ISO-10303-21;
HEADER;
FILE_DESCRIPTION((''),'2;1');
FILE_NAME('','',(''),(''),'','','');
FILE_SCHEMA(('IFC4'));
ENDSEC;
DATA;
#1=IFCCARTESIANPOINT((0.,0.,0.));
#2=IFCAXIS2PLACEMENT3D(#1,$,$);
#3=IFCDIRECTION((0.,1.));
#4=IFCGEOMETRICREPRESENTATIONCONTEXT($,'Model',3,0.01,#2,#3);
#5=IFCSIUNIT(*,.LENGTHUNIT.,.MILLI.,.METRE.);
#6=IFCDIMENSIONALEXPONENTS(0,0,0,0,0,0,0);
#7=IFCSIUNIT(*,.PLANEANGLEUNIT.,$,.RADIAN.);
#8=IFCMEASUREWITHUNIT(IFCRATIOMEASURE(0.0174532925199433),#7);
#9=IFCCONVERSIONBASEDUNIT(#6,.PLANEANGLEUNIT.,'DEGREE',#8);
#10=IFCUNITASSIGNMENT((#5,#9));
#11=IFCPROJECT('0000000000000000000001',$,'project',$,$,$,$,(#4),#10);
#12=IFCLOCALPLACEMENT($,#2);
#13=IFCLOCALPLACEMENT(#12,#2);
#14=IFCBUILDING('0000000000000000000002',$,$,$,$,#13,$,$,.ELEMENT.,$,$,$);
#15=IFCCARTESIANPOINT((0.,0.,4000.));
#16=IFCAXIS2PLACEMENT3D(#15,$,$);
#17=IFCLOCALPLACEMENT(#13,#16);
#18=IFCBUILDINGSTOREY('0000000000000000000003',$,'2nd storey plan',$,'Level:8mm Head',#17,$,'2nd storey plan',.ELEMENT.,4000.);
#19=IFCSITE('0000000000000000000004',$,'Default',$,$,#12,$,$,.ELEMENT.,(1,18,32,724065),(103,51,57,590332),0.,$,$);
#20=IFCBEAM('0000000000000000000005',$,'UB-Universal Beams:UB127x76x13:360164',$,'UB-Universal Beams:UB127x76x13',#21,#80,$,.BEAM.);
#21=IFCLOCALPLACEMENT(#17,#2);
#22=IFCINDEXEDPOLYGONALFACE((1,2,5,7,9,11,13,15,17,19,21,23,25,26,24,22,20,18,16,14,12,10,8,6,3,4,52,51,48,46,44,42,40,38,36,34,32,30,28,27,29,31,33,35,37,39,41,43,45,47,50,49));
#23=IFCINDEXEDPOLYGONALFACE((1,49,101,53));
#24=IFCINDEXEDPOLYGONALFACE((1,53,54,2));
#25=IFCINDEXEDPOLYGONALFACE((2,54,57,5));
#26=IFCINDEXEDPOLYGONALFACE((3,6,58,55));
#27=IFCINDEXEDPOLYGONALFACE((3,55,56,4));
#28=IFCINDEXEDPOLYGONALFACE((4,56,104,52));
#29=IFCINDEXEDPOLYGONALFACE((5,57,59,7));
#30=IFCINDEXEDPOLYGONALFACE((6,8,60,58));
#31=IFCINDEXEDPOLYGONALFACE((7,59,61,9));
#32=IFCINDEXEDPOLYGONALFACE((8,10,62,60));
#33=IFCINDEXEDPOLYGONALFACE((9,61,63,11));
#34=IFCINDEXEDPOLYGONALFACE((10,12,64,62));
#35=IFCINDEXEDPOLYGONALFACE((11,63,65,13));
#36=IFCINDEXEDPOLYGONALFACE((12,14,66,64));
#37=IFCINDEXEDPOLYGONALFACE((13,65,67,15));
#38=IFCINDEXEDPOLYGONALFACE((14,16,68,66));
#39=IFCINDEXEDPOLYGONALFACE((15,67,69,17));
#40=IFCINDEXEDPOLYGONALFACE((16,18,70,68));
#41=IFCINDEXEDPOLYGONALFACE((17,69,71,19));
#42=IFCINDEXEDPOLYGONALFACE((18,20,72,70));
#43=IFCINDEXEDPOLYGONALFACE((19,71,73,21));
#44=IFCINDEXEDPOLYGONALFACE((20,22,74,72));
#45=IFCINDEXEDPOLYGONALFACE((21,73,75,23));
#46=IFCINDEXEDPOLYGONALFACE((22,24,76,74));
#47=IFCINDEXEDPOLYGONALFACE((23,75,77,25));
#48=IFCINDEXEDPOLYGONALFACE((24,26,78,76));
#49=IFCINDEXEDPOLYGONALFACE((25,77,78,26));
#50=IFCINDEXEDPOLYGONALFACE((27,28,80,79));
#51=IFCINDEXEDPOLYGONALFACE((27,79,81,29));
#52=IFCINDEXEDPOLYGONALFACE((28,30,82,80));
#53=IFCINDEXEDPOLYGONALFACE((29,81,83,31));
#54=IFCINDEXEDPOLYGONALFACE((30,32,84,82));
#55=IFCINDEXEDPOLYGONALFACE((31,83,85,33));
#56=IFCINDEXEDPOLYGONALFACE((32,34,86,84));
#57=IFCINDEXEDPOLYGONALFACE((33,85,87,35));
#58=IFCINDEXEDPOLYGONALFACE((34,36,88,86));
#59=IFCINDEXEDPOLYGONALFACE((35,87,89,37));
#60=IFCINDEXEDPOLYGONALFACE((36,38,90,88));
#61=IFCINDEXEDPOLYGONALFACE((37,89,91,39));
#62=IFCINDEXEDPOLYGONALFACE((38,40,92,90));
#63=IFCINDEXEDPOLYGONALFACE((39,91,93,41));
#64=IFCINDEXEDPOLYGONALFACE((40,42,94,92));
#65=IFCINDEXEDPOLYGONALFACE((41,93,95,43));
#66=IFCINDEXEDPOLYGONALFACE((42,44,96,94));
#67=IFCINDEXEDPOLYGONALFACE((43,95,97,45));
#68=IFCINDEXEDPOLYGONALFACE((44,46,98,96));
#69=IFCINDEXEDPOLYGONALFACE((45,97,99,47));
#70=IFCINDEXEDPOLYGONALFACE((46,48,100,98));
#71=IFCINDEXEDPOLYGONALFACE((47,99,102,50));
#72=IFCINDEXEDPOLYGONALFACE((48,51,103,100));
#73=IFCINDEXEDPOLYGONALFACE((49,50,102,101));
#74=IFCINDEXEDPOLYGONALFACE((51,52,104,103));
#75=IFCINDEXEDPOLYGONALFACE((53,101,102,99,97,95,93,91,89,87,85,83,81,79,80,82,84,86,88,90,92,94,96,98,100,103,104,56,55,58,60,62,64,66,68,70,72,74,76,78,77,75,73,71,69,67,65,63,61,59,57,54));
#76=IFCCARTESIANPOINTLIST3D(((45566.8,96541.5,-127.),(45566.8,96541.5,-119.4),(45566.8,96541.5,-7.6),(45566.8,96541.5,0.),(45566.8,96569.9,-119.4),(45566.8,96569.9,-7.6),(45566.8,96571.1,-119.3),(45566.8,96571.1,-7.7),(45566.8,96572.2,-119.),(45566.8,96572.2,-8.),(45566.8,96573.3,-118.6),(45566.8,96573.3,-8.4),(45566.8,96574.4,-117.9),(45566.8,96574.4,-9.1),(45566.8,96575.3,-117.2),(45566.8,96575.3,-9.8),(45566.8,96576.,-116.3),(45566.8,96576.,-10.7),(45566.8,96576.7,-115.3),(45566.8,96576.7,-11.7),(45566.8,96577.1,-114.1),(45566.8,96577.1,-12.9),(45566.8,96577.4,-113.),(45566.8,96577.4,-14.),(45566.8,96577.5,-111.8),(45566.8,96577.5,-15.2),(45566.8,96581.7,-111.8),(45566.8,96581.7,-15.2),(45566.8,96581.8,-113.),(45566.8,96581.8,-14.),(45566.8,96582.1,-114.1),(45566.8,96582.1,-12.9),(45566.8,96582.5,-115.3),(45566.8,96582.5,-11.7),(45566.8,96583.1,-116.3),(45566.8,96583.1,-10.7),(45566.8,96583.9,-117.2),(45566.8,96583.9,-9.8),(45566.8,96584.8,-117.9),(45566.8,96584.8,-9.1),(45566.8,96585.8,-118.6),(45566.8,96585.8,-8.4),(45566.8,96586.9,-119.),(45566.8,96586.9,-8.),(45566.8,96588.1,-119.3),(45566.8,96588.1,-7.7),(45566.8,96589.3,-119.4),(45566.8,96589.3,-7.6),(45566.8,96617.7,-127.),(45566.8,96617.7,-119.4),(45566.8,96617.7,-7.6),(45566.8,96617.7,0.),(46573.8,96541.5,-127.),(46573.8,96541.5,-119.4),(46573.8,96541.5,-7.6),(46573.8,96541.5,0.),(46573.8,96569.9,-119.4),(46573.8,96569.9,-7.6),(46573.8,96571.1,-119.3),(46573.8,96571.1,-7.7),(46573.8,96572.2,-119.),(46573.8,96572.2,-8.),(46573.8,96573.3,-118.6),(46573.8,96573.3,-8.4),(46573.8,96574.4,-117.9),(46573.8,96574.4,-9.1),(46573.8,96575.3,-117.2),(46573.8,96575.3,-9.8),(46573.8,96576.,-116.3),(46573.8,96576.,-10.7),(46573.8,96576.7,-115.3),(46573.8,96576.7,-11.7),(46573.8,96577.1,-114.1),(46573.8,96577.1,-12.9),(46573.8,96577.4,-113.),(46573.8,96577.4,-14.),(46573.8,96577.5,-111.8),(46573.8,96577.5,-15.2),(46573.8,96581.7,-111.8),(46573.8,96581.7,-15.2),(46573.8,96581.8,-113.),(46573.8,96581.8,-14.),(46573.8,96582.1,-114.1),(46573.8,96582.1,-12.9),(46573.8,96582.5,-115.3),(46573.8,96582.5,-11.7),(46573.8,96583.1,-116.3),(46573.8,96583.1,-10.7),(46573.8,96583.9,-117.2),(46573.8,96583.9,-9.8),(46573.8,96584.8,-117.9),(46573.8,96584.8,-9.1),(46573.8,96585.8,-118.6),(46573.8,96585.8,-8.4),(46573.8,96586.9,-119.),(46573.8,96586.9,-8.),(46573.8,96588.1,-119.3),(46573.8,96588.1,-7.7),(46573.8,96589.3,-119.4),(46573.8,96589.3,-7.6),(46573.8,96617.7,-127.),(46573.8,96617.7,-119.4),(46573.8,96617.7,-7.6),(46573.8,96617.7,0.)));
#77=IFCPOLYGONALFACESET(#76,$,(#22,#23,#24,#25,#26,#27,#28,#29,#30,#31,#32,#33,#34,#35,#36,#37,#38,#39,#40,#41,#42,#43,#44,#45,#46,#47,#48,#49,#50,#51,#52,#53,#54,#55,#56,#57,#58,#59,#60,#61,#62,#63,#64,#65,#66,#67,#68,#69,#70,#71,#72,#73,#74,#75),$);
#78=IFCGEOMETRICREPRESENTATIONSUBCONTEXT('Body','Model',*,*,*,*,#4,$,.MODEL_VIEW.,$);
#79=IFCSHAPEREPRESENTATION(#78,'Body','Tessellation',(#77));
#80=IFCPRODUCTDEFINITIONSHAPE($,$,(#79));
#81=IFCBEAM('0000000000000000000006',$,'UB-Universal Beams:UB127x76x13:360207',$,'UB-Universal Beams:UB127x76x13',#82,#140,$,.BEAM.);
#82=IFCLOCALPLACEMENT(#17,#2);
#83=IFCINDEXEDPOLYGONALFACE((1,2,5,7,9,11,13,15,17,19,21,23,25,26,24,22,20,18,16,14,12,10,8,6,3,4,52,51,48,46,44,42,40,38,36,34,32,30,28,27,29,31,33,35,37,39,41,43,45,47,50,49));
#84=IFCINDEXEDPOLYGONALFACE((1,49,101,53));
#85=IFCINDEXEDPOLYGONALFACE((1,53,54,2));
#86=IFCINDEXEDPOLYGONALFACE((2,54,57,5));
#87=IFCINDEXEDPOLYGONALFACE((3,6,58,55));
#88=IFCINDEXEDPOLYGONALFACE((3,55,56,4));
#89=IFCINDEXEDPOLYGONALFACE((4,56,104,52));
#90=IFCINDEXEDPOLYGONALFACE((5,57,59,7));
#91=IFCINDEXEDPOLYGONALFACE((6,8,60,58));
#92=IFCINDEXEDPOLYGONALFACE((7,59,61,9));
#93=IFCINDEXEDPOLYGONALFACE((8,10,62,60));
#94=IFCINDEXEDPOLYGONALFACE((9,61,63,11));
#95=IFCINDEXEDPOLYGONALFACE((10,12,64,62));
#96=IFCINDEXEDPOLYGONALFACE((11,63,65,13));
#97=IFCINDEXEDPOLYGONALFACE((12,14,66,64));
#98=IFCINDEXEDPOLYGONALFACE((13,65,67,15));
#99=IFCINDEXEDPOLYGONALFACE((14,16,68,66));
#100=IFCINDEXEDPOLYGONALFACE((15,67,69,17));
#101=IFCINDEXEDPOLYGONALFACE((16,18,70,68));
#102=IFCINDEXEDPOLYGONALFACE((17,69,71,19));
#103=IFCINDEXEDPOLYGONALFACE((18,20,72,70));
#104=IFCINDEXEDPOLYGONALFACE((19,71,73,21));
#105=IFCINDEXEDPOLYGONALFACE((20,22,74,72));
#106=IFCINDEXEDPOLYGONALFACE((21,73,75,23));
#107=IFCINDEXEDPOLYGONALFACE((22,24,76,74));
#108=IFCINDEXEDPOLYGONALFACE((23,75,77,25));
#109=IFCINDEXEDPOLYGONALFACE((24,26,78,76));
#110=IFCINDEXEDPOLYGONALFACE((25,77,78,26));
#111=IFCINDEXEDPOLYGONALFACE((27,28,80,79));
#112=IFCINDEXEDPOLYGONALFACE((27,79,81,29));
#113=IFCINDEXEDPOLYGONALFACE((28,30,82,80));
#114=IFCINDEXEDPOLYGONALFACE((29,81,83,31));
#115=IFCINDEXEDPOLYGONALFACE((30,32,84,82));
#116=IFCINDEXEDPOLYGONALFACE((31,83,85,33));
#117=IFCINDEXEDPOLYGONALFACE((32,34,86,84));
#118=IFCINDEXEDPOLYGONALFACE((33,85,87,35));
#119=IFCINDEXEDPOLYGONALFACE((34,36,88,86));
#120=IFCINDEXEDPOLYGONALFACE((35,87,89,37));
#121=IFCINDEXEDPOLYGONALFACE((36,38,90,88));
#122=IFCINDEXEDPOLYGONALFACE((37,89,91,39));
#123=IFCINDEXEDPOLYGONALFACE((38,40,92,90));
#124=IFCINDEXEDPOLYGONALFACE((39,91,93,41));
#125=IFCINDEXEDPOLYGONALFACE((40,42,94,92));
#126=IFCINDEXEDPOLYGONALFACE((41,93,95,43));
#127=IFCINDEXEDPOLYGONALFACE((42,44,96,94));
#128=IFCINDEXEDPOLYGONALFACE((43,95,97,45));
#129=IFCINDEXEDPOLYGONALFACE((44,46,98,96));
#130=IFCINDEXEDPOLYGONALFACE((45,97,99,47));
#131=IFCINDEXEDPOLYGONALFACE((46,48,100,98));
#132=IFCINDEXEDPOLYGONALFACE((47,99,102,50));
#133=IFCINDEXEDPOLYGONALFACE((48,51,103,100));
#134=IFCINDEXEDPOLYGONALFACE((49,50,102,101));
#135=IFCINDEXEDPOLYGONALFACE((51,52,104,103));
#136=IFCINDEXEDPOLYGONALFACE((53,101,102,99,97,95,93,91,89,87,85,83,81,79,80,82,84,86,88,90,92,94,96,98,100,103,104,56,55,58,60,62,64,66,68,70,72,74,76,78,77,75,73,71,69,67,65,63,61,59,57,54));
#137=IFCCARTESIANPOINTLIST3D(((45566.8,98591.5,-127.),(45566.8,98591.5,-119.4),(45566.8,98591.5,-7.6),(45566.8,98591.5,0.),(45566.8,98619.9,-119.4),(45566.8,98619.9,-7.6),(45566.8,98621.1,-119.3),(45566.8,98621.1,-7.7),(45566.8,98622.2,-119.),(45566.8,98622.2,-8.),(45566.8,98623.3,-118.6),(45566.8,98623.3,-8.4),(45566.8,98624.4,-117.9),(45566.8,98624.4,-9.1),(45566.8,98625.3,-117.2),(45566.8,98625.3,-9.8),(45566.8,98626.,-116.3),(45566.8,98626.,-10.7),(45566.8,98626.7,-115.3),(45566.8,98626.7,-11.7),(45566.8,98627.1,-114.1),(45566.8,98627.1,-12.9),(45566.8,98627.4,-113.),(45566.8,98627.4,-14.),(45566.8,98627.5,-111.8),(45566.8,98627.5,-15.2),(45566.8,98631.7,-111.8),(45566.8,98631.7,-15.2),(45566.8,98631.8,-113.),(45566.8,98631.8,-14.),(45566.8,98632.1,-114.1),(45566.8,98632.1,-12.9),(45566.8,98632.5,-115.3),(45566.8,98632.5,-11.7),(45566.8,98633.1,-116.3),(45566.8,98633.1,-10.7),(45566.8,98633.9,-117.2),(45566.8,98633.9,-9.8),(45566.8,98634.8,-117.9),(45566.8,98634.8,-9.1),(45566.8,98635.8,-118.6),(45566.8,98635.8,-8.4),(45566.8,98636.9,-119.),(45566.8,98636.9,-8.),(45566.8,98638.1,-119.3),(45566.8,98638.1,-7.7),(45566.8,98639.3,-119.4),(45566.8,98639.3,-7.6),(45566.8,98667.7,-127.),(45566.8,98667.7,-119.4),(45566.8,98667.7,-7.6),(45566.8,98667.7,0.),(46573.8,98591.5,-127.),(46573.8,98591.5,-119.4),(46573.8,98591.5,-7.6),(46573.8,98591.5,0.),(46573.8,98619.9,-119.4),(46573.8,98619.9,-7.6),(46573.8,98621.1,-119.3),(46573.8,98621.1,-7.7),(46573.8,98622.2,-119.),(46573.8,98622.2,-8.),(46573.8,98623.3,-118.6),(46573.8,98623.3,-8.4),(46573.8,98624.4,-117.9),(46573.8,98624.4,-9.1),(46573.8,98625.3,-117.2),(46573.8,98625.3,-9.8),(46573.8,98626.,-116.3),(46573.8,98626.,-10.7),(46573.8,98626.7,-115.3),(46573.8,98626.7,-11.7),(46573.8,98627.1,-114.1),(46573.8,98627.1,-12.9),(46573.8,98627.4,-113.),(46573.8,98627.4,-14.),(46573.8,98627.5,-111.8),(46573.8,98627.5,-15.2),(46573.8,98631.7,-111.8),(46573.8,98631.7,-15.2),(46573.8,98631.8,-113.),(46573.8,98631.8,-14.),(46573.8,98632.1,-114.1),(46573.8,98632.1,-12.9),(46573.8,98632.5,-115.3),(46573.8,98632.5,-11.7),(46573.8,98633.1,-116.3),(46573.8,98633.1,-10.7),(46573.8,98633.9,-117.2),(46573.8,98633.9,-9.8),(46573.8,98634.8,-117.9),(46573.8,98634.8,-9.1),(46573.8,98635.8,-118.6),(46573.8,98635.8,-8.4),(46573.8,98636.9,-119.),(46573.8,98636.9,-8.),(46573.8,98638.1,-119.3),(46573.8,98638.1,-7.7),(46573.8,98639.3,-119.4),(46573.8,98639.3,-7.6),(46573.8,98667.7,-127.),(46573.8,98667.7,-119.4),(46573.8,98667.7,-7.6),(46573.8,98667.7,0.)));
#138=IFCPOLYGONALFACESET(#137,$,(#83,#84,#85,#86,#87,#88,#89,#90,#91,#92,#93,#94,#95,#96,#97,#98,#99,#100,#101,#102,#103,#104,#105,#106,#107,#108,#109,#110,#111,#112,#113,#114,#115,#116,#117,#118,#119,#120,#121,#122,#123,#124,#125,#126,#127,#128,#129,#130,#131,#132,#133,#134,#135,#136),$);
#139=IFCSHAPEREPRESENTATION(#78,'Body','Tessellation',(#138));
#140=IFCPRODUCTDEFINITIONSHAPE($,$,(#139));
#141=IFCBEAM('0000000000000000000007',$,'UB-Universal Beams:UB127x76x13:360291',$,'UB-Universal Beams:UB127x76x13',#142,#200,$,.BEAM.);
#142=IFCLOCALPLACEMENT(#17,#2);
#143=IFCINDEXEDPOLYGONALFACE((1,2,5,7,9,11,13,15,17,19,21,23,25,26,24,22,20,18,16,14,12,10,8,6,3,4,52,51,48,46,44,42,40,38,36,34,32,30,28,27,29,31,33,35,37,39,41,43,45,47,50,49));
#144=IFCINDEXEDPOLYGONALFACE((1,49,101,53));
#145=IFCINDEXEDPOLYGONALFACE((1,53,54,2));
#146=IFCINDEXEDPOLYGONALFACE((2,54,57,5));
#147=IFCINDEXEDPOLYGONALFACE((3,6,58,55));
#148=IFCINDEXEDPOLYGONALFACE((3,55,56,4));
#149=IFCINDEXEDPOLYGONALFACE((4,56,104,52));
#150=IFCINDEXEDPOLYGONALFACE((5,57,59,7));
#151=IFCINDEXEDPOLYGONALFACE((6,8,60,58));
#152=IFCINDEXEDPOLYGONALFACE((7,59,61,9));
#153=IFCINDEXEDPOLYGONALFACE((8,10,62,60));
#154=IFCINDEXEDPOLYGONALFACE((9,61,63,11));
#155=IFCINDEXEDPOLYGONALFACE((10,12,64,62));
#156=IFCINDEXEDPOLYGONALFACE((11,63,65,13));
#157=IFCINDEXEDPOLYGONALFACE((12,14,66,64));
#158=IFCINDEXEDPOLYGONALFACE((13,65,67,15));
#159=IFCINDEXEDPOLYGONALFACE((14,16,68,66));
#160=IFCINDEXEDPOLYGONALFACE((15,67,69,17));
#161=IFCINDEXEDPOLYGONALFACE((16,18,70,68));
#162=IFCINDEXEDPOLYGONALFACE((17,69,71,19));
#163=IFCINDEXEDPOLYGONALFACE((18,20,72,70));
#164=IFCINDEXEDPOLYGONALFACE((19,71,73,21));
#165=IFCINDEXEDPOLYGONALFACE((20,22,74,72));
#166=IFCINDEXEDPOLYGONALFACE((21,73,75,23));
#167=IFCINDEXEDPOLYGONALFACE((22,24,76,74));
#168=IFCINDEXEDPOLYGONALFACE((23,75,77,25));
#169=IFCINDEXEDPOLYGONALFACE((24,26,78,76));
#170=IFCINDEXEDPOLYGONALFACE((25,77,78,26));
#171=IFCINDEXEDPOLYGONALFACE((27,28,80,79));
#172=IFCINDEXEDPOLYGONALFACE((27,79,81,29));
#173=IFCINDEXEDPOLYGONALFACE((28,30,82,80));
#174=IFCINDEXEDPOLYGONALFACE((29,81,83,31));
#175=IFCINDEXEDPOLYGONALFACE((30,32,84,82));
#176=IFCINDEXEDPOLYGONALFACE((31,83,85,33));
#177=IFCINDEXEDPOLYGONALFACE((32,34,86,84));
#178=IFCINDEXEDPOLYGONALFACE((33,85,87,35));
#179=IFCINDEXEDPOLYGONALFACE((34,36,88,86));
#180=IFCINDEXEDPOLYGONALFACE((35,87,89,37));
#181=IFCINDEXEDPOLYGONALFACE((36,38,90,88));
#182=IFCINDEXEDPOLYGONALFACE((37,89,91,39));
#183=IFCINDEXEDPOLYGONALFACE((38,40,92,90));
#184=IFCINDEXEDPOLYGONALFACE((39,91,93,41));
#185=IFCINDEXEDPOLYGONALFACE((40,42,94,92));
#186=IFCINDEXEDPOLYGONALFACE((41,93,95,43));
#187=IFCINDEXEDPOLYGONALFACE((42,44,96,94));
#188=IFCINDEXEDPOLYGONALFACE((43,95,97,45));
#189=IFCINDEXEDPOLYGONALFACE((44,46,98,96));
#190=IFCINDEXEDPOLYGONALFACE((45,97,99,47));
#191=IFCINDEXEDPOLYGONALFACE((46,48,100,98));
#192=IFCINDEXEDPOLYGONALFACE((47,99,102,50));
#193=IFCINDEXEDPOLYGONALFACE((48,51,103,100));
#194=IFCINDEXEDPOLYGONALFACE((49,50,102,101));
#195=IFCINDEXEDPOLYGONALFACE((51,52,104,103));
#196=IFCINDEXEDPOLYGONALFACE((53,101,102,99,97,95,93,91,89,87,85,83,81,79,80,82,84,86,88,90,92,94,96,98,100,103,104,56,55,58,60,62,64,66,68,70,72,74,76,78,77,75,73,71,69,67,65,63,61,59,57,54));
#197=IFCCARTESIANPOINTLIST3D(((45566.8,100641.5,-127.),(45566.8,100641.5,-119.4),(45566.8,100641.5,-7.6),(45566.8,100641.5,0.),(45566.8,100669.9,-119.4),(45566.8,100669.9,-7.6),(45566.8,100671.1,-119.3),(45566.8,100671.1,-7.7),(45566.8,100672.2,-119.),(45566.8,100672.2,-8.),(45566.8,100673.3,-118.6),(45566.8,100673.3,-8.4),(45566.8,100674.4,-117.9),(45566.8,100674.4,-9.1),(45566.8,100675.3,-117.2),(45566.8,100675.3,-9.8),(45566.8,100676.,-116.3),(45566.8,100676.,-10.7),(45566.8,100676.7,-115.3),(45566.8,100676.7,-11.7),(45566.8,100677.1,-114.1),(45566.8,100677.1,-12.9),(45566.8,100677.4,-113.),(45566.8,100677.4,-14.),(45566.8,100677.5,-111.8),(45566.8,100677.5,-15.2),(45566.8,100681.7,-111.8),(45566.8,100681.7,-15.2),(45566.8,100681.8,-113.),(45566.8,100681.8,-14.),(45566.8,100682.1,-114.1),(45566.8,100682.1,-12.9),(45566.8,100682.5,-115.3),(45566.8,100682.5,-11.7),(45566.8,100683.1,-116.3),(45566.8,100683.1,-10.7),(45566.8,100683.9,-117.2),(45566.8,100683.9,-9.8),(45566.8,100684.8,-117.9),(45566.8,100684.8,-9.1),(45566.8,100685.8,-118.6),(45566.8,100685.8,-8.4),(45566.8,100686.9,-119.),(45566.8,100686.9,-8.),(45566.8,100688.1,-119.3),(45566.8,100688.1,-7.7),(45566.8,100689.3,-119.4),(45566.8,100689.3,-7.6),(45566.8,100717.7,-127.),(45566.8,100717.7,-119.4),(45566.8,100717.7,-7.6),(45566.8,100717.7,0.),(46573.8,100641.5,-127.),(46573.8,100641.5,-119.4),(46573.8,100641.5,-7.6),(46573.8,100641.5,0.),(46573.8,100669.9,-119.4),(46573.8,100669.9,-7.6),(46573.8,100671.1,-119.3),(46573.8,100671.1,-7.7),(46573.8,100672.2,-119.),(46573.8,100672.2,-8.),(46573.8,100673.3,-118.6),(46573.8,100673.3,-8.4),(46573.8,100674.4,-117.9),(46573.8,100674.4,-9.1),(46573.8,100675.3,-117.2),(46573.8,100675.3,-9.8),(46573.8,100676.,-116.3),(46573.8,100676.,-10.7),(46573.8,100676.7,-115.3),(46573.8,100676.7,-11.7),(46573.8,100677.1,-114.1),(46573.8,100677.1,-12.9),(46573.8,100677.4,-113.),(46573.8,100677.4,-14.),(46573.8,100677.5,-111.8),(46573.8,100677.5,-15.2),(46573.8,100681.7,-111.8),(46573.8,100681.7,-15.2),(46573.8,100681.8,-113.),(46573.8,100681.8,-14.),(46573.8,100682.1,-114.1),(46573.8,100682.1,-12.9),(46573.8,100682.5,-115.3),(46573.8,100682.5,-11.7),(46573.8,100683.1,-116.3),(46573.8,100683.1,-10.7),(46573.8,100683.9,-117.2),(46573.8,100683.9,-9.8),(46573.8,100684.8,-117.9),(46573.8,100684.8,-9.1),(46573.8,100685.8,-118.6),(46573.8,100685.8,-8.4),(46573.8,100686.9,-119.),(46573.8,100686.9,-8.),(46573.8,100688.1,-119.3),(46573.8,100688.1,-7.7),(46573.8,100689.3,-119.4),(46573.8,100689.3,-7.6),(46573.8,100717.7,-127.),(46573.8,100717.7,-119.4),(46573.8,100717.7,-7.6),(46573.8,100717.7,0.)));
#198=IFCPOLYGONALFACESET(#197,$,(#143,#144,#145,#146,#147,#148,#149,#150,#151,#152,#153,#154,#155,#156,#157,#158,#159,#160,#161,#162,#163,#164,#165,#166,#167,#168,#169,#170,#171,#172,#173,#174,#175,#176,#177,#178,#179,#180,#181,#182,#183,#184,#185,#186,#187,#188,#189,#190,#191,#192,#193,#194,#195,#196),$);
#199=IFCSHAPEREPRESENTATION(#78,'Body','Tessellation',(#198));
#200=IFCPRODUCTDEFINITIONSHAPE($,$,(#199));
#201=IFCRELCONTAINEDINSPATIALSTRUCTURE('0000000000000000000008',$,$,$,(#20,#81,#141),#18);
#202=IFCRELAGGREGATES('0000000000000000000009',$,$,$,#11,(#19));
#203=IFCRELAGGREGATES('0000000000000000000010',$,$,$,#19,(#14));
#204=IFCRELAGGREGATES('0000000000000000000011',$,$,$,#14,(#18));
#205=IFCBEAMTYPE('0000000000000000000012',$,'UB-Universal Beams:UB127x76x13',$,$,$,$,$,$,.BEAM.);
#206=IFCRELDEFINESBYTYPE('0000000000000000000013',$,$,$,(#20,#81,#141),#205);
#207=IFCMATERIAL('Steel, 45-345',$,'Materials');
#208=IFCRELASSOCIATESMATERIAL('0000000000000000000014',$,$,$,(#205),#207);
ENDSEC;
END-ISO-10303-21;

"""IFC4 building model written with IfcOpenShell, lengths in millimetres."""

from ifc_helpers import new_model, entity, si_unit, converted_unit, direction, frame, origin, place, context, subcontext, project, spatial, indexed_curve, outline, extrude, source, transform, mapped, material, type_object, type_shapes, element, save


model = new_model("IFC4")

# Units and contexts
model_context = context("Model", 3, precision=0.01, world=origin(), true_north=direction((0.0, 1.0)))
body_context = subcontext(model_context, "Body", "Model", "MODEL_VIEW")
ifc_project = project(units=[si_unit("LENGTHUNIT", "METRE", prefix="MILLI"), converted_unit("PLANEANGLEUNIT", "DEGREE", entity("IfcRatioMeasure", 0.0174532925199433), si_unit("PLANEANGLEUNIT", "RADIAN"), dimensions=[0, 0, 0, 0, 0, 0, 0])], contexts=[model_context])

# Site, building, storey
site_placement = place(None, origin())
site = spatial("IfcSite", under=ifc_project, at=site_placement, Name="Default", CompositionType="ELEMENT", RefLatitude=(1, 18, 32, 724065), RefLongitude=(103, 51, 57, 590332), RefElevation=0.0)
building_placement = place(site_placement, origin())
building = spatial("IfcBuilding", under=site, at=building_placement, CompositionType="ELEMENT")
storey_placement = place(building_placement, frame((0.0, 0.0, 4000.0)))
storey = spatial("IfcBuildingStorey", under=building, at=storey_placement, Name="2nd storey plan", ObjectType="Level:8mm Head", LongName="2nd storey plan", CompositionType="ELEMENT", Elevation=4000.0)

# Beams
ifc_material_1 = material(Name="Steel, 45-345", Category="Materials")
beam_type_1 = type_object("IfcBeamType", Name="UB-Universal Beams:UB127x76x13", PredefinedType="BEAM", material=ifc_material_1)
shared_shape_1 = source(origin(), body_context, "Body", "SweptSolid", [
    extrude(outline(indexed_curve([(-63.5, -38.1), (-55.9, -38.1), (-55.9, -9.7), (-55.8, -8.5), (-55.5, -7.4), (-55.1, -6.2), (-54.4, -5.2), (-53.7, -4.3), (-52.8, -3.6), (-51.8, -2.9), (-50.6, -2.5), (-49.5, -2.2), (-48.3, -2.1), (48.3, -2.1), (49.5, -2.2), (50.6, -2.5), (51.8, -2.9), (52.8, -3.6), (53.7, -4.3), (54.4, -5.2), (55.1, -6.2), (55.5, -7.4), (55.8, -8.5), (55.9, -9.7), (55.9, -38.1), (63.5, -38.1), (63.5, 38.1), (55.9, 38.1), (55.9, 9.7), (55.8, 8.5), (55.5, 7.4), (55.1, 6.2), (54.4, 5.2), (53.7, 4.3), (52.8, 3.6), (51.8, 2.9), (50.6, 2.5), (49.5, 2.2), (48.3, 2.1), (-48.3, 2.1), (-49.5, 2.2), (-50.6, 2.5), (-51.8, 2.9), (-52.8, 3.6), (-53.7, 4.3), (-54.4, 5.2), (-55.1, 6.2), (-55.5, 7.4), (-55.8, 8.5), (-55.9, 9.7), (-55.9, 38.1), (-63.5, 38.1), (-63.5, -38.1)], self_intersect=False)), frame((-570.0, 0.0, 0.0), z_axis=(1.0, 0.0, 0.0), x_axis=(0.0, 0.0, -1.0)), (0.0, 0.0, 1.0), 1007.0),
])
type_shapes(beam_type_1, [shared_shape_1])
for number, where, name in (
    (1, (46136.8, 96579.6, -63.5), "UB-Universal Beams:UB127x76x13:360164"),
    (2, (46136.8, 98629.6, -63.5), "UB-Universal Beams:UB127x76x13:360207"),
    (3, (46136.8, 100679.6, -63.5), "UB-Universal Beams:UB127x76x13:360291"),
):
    element("IfcBeam", number, at=place(storey_placement, frame(where)), inside=storey, type_object=beam_type_1, Name=name, ObjectType="UB-Universal Beams:UB127x76x13", PredefinedType="BEAM", context=body_context, shape_type="MappedRepresentation", body=[
        mapped(shared_shape_1, transform((0.0, 0.0, 0.0), scale=1.0)),
    ])

save(model, "model.ifc")
